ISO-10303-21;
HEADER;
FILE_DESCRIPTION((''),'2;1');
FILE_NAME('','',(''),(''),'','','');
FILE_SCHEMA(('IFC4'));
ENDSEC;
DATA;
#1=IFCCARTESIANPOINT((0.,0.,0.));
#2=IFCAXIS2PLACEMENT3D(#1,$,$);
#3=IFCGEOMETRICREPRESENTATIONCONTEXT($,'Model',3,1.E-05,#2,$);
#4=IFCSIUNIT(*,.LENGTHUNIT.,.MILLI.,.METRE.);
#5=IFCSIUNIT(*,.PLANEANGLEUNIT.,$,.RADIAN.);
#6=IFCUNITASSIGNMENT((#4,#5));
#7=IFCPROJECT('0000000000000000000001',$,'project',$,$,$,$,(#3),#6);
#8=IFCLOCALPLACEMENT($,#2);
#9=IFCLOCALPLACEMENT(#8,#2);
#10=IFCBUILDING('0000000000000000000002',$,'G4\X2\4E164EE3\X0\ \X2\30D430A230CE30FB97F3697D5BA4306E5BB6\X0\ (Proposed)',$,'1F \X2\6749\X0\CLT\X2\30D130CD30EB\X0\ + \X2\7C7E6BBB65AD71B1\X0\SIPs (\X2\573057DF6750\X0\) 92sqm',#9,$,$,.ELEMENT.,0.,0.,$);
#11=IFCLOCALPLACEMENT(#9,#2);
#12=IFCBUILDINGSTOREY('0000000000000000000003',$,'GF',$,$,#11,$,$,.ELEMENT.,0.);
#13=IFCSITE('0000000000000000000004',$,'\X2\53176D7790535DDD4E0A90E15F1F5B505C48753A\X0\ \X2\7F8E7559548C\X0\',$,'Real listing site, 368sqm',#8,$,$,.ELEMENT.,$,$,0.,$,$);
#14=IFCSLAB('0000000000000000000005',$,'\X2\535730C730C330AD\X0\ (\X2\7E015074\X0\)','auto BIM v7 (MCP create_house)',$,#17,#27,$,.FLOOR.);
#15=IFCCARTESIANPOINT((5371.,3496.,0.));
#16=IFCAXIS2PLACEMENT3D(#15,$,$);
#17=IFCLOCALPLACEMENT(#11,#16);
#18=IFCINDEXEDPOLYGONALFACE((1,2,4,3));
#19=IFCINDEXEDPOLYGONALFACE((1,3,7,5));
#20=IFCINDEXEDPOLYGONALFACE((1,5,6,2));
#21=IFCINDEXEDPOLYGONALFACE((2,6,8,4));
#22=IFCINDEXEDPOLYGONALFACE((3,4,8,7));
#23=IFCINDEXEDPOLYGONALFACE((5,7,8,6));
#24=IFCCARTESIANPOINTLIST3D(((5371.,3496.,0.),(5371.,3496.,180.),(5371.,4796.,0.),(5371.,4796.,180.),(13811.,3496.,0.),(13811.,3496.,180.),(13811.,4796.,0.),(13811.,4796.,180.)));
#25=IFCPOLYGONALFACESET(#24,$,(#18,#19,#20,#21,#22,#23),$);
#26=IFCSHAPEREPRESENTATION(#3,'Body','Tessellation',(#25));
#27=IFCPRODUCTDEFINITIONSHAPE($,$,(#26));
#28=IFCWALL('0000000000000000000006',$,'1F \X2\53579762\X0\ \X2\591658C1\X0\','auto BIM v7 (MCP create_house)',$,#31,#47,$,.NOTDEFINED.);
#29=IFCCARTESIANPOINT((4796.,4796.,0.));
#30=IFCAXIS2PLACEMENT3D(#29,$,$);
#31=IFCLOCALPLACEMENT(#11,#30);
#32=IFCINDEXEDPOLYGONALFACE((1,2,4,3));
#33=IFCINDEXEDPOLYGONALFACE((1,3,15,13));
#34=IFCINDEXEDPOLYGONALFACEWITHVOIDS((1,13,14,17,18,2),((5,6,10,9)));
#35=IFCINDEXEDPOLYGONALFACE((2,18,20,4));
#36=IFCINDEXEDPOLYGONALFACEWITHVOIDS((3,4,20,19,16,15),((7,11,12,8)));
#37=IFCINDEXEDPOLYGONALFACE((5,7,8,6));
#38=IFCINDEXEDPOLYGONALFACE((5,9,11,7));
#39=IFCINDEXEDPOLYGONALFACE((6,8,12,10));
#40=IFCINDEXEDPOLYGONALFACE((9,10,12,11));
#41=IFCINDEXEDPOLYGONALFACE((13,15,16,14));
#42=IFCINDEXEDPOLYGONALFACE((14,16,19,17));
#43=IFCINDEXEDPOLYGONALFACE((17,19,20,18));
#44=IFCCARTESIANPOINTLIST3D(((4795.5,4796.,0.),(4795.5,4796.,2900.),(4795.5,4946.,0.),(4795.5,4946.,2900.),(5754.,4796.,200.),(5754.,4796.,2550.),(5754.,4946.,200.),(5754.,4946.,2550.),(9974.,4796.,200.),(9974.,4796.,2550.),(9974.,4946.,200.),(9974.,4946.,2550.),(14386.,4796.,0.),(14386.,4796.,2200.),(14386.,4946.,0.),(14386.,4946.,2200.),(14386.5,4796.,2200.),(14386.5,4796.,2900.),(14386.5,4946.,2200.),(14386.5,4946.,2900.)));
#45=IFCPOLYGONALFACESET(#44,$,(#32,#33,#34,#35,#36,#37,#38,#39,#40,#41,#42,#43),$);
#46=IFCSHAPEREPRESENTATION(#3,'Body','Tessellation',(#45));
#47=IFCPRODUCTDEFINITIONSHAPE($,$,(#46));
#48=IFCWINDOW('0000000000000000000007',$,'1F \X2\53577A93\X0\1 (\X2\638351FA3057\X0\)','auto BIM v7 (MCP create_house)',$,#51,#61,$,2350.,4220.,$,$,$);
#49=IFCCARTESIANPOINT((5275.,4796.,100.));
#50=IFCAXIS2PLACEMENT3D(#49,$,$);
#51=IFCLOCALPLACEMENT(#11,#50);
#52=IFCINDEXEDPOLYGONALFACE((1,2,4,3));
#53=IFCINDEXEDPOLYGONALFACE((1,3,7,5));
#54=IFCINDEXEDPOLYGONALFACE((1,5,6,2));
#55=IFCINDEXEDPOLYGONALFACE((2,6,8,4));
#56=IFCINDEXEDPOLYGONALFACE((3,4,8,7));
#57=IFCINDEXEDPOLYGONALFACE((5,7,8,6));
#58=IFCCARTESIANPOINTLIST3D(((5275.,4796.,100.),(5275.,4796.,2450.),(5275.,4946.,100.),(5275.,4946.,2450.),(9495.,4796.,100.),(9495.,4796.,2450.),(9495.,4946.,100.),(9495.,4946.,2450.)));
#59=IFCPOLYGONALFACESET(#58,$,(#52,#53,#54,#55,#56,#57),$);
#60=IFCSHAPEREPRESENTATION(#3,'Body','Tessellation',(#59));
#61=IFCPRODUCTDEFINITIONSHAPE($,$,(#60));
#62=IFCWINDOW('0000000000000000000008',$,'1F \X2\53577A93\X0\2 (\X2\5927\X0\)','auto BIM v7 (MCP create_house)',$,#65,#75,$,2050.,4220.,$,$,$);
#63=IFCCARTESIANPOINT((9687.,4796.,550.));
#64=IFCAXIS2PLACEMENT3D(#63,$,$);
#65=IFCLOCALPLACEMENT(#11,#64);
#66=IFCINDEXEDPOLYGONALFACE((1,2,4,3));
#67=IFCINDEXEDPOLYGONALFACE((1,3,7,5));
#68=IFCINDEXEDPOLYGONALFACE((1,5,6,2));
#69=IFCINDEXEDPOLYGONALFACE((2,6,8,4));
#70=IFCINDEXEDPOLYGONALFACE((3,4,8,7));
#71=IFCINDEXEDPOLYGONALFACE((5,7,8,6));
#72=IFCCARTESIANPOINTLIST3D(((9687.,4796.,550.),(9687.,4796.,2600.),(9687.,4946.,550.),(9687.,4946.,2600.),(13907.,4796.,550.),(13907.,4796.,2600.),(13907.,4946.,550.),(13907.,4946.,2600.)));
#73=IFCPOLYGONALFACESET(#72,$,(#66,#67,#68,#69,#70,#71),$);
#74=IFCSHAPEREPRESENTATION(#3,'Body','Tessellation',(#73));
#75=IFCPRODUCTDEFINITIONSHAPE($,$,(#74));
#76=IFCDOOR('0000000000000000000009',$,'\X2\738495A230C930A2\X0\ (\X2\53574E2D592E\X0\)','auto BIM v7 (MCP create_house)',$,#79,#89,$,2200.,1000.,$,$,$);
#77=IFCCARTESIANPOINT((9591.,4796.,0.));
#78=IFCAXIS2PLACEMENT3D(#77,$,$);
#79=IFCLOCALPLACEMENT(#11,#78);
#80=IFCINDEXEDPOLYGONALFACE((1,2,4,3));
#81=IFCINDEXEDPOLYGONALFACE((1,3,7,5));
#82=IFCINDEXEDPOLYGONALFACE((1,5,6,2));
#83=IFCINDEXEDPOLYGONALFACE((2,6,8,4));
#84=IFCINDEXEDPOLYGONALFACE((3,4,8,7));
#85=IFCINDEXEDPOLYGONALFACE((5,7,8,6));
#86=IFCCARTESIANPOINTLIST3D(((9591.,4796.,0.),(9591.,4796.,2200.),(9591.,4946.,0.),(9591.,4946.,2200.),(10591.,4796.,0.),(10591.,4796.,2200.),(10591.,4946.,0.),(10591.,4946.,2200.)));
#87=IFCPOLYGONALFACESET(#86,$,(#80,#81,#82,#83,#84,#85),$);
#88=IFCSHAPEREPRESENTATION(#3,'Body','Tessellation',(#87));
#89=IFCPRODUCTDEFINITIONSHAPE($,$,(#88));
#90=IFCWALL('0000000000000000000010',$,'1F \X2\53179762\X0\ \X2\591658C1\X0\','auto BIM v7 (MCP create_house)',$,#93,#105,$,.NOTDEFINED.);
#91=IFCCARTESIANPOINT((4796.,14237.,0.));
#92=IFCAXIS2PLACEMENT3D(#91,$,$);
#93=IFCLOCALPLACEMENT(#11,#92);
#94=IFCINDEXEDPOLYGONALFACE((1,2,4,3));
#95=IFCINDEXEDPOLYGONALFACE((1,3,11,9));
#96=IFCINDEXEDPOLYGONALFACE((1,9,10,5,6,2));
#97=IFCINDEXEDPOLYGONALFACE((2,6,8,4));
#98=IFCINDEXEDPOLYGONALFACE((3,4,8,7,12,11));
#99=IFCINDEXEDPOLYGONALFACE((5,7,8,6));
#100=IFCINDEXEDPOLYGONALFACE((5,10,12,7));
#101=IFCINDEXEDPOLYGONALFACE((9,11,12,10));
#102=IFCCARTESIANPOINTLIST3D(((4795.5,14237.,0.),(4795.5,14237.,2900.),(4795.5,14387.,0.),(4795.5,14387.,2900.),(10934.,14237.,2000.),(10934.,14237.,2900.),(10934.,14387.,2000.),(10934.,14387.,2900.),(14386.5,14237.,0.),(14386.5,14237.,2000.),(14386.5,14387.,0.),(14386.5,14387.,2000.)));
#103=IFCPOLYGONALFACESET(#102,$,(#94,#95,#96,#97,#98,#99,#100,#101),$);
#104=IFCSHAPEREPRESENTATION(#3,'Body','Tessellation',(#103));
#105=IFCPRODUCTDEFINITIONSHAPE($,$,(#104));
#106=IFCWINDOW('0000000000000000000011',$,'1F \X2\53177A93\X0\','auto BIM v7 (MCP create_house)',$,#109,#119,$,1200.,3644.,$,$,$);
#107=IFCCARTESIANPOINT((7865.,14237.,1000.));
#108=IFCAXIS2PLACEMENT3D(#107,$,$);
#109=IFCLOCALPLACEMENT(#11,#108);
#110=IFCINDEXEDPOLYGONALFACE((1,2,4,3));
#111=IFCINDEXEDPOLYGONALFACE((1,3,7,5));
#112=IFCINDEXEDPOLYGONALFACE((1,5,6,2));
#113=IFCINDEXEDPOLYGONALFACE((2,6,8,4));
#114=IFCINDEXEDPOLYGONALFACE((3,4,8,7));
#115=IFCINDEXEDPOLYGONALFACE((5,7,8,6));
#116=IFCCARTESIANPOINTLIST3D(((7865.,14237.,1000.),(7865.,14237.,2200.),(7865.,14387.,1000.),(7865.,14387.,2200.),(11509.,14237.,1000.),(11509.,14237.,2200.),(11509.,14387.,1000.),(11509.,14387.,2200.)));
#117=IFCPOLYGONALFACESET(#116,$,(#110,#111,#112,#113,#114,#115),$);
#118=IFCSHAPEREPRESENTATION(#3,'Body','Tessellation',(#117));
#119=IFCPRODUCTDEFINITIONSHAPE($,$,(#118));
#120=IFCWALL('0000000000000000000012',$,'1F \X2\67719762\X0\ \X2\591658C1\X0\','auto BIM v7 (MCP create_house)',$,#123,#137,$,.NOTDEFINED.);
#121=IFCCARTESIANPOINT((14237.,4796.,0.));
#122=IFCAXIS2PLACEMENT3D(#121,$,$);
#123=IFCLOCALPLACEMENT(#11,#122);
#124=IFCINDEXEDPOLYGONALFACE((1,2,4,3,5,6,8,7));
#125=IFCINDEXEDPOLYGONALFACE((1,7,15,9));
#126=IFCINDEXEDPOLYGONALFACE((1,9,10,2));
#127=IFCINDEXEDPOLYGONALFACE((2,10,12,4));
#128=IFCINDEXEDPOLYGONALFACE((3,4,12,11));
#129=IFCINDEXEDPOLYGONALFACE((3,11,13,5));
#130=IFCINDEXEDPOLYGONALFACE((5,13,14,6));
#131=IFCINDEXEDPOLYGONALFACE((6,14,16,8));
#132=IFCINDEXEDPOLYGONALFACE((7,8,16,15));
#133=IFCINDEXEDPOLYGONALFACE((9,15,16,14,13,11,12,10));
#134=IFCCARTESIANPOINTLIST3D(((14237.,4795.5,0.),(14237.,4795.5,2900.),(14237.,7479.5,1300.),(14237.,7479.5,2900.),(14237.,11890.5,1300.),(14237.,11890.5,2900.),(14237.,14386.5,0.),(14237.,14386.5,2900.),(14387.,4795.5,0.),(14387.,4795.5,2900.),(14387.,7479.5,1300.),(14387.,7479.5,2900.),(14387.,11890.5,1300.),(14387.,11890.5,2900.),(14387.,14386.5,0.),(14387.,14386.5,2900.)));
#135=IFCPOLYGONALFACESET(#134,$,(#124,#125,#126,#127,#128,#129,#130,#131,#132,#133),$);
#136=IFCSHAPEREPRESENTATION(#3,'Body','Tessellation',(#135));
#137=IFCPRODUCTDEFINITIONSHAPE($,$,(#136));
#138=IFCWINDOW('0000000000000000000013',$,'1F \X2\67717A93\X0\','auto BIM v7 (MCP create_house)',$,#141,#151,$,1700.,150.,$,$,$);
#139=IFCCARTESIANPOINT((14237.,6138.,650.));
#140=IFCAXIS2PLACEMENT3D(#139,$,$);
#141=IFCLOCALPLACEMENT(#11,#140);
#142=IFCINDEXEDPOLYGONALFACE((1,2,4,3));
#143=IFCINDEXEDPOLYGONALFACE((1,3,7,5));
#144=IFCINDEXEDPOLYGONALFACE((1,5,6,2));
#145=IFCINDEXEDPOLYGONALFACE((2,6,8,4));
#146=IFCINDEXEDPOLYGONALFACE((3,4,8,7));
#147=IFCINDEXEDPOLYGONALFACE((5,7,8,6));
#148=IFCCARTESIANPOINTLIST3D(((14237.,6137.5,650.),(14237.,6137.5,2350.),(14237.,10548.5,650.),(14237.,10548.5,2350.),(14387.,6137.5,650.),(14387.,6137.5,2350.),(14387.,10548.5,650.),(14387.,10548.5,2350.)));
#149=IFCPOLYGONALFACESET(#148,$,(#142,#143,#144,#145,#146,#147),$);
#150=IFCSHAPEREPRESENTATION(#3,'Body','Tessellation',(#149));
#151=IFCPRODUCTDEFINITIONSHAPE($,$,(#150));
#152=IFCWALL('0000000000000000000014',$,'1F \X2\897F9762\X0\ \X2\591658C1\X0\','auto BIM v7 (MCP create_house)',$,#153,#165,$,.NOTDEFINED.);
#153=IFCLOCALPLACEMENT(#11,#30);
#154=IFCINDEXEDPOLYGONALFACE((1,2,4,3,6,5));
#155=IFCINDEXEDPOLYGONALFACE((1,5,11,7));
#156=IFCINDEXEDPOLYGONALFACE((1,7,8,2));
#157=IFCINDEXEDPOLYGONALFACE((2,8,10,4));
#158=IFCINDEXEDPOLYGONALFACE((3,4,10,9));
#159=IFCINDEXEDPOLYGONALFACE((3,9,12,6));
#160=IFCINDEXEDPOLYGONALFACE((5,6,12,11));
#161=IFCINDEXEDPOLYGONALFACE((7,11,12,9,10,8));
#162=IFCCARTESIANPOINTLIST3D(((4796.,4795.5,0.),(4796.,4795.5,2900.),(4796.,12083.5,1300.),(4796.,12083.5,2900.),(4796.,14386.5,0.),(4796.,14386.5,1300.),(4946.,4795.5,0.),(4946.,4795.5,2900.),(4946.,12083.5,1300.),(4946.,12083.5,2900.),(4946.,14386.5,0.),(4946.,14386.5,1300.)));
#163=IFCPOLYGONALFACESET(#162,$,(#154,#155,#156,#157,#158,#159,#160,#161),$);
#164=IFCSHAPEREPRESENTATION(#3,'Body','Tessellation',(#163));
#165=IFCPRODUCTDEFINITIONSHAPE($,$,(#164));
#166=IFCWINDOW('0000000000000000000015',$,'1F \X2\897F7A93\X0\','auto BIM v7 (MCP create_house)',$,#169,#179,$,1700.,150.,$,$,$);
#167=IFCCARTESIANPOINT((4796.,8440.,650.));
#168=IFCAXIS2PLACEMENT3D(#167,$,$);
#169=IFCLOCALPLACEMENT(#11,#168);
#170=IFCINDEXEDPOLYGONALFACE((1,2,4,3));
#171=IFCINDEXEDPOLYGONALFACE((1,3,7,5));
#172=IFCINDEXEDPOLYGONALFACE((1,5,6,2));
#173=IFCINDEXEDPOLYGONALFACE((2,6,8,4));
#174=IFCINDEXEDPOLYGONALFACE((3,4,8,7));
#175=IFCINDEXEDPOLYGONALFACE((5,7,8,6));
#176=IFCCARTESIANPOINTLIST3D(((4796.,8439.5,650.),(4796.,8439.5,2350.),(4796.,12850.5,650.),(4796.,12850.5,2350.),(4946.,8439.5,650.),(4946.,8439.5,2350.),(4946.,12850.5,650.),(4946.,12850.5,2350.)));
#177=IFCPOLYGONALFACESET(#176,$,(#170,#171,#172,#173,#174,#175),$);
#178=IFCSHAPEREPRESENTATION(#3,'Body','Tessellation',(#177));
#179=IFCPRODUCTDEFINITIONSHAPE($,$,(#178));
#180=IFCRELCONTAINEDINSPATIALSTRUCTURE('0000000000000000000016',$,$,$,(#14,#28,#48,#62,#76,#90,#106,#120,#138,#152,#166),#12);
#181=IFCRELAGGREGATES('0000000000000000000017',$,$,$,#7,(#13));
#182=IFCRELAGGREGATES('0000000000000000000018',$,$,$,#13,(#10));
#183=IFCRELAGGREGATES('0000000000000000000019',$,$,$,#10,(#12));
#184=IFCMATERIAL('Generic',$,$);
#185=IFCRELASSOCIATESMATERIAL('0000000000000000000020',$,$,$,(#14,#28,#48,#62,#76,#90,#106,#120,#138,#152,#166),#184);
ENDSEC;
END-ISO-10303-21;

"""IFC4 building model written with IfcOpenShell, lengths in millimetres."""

from ifc_helpers import new_model, si_unit, frame, frame_2d, origin, place, context, project, spatial, rectangle, extrude, material, element, fill, save


model = new_model("IFC4")

# Units and contexts
model_context = context("Model", 3, precision=1e-05, world=origin())
ifc_project = project(units=[si_unit("LENGTHUNIT", "METRE", prefix="MILLI"), si_unit("PLANEANGLEUNIT", "RADIAN")], contexts=[model_context])

# Site, building, storey
site_placement = place(None, origin())
site = spatial("IfcSite", under=ifc_project, at=site_placement, Name="北海道川上郡弟子屈町 美留和", ObjectType="Real listing site, 368sqm", CompositionType="ELEMENT", RefElevation=0.0)
building_placement = place(site_placement, origin())
building = spatial("IfcBuilding", under=site, at=building_placement, Name="G4世代 ピアノ・音楽室の家 (Proposed)", ObjectType="1F 杉CLTパネル + 籾殻断熱SIPs (地域材) 92sqm", CompositionType="ELEMENT", ElevationOfRefHeight=0.0, ElevationOfTerrain=0.0)
storey_placement = place(building_placement, origin())
storey = spatial("IfcBuildingStorey", under=building, at=storey_placement, Name="GF", CompositionType="ELEMENT", Elevation=0.0)

# Slab
ifc_material = material(Name="Generic")
slab_1_placement = place(storey_placement, frame((5371.0, 3496.0, 0.0)))
element("IfcSlab", 1, at=slab_1_placement, inside=storey, material=ifc_material, Name="南デッキ (縁側)", Description="auto BIM v7 (MCP create_house)", PredefinedType="FLOOR", context=model_context, shape_type="SweptSolid", body=[
    extrude(rectangle(XDim=8440.0, YDim=1300.0, at=frame_2d((4220.0, 650.0))), frame((5371.0, 3496.0, 0.0)), (0.0, 0.0, 1.0), 180.0),
])

# Wall, openings, windows, door
wall_1_placement = place(storey_placement, frame((4796.0, 4796.0, 0.0)))
wall_1 = element("IfcWall", 2, at=wall_1_placement, inside=storey, material=ifc_material, Name="1F 南面 外壁", Description="auto BIM v7 (MCP create_house)", PredefinedType="NOTDEFINED", context=model_context, shape_type="SweptSolid", body=[
    extrude(rectangle(XDim=9591.0, YDim=150.0, at=frame_2d((4795.0, 75.0))), frame((4796.0, 4796.0, 0.0)), (0.0, 0.0, 1.0), 2900.0),
])
opening_1_placement = place(storey_placement, frame((5275.0, 4796.0, 100.0)))
opening_1 = element("IfcOpeningElement", 3, at=opening_1_placement, cuts=wall_1, PredefinedType="NOTDEFINED", context=model_context, shape_type="SweptSolid", body=[
    extrude(rectangle(XDim=4220.0, YDim=150.0, at=frame_2d((2110.0, 75.0))), frame((5275.0, 4796.0, 100.0)), (0.0, 0.0, 1.0), 2350.0),
])
opening_2_placement = place(storey_placement, frame((9687.0, 4796.0, 550.0)))
opening_2 = element("IfcOpeningElement", 4, at=opening_2_placement, cuts=wall_1, PredefinedType="NOTDEFINED", context=model_context, shape_type="SweptSolid", body=[
    extrude(rectangle(XDim=4220.0, YDim=150.0, at=frame_2d((2110.0, 75.0))), frame((9687.0, 4796.0, 550.0)), (0.0, 0.0, 1.0), 2050.0),
])
opening_3_placement = place(storey_placement, frame((9591.0, 4796.0, 0.0)))
opening_3 = element("IfcOpeningElement", 5, at=opening_3_placement, cuts=wall_1, PredefinedType="NOTDEFINED", context=model_context, shape_type="SweptSolid", body=[
    extrude(rectangle(XDim=1000.0, YDim=150.0, at=frame_2d((500.0, 75.0))), frame((9591.0, 4796.0, 0.0)), (0.0, 0.0, 1.0), 2200.0),
])
window_1_placement = place(storey_placement, frame((5275.0, 4796.0, 100.0)))
window_1 = element("IfcWindow", 6, at=window_1_placement, inside=storey, material=ifc_material, Name="1F 南窓1 (掃出し)", Description="auto BIM v7 (MCP create_house)", OverallHeight=2350.0, OverallWidth=4220.0, context=model_context, shape_type="SweptSolid", body=[
    extrude(rectangle(XDim=4220.0, YDim=150.0, at=frame_2d((2110.0, 75.0))), frame((5275.0, 4796.0, 100.0)), (0.0, 0.0, 1.0), 2350.0),
])
fill(opening_1, window_1)
window_2_placement = place(storey_placement, frame((9687.0, 4796.0, 550.0)))
window_2 = element("IfcWindow", 7, at=window_2_placement, inside=storey, material=ifc_material, Name="1F 南窓2 (大)", Description="auto BIM v7 (MCP create_house)", OverallHeight=2050.0, OverallWidth=4220.0, context=model_context, shape_type="SweptSolid", body=[
    extrude(rectangle(XDim=4220.0, YDim=150.0, at=frame_2d((2110.0, 75.0))), frame((9687.0, 4796.0, 550.0)), (0.0, 0.0, 1.0), 2050.0),
])
fill(opening_2, window_2)
door_placement = place(storey_placement, frame((9591.0, 4796.0, 0.0)))
door = element("IfcDoor", 8, at=door_placement, inside=storey, material=ifc_material, Name="玄関ドア (南中央)", Description="auto BIM v7 (MCP create_house)", OverallHeight=2200.0, OverallWidth=1000.0, context=model_context, shape_type="SweptSolid", body=[
    extrude(rectangle(XDim=1000.0, YDim=150.0, at=frame_2d((500.0, 75.0))), frame((9591.0, 4796.0, 0.0)), (0.0, 0.0, 1.0), 2200.0),
])
fill(opening_3, door)

# Walls, openings, windows
wall_2_placement = place(storey_placement, frame((4796.0, 14237.0, 0.0)))
wall_2 = element("IfcWall", 9, at=wall_2_placement, inside=storey, material=ifc_material, Name="1F 北面 外壁", Description="auto BIM v7 (MCP create_house)", PredefinedType="NOTDEFINED", context=model_context, shape_type="SweptSolid", body=[
    extrude(rectangle(XDim=9591.0, YDim=150.0, at=frame_2d((4795.0, 75.0))), frame((4796.0, 14237.0, 0.0)), (0.0, 0.0, 1.0), 2900.0),
])
opening_4_placement = place(storey_placement, frame((7865.0, 14237.0, 1000.0)))
opening_4 = element("IfcOpeningElement", 10, at=opening_4_placement, cuts=wall_2, PredefinedType="NOTDEFINED", context=model_context, shape_type="SweptSolid", body=[
    extrude(rectangle(XDim=3644.0, YDim=150.0, at=frame_2d((1822.0, 75.0))), frame((7865.0, 14237.0, 1000.0)), (0.0, 0.0, 1.0), 1200.0),
])
window_3_placement = place(storey_placement, frame((7865.0, 14237.0, 1000.0)))
window_3 = element("IfcWindow", 11, at=window_3_placement, inside=storey, material=ifc_material, Name="1F 北窓", Description="auto BIM v7 (MCP create_house)", OverallHeight=1200.0, OverallWidth=3644.0, context=model_context, shape_type="SweptSolid", body=[
    extrude(rectangle(XDim=3644.0, YDim=150.0, at=frame_2d((1822.0, 75.0))), frame((7865.0, 14237.0, 1000.0)), (0.0, 0.0, 1.0), 1200.0),
])
fill(opening_4, window_3)
wall_3_placement = place(storey_placement, frame((14237.0, 4796.0, 0.0)))
wall_3 = element("IfcWall", 12, at=wall_3_placement, inside=storey, material=ifc_material, Name="1F 東面 外壁", Description="auto BIM v7 (MCP create_house)", PredefinedType="NOTDEFINED", context=model_context, shape_type="SweptSolid", body=[
    extrude(rectangle(XDim=150.0, YDim=9591.0, at=frame_2d((75.0, 4795.0))), frame((14237.0, 4796.0, 0.0)), (0.0, 0.0, 1.0), 2900.0),
])
opening_5_placement = place(storey_placement, frame((14237.0, 6138.0, 650.0)))
opening_5 = element("IfcOpeningElement", 13, at=opening_5_placement, cuts=wall_3, PredefinedType="NOTDEFINED", context=model_context, shape_type="SweptSolid", body=[
    extrude(rectangle(XDim=150.0, YDim=4411.0, at=frame_2d((75.0, 2205.0))), frame((14237.0, 6138.0, 650.0)), (0.0, 0.0, 1.0), 1700.0),
])
window_4_placement = place(storey_placement, frame((14237.0, 6138.0, 650.0)))
window_4 = element("IfcWindow", 14, at=window_4_placement, inside=storey, material=ifc_material, Name="1F 東窓", Description="auto BIM v7 (MCP create_house)", OverallHeight=1700.0, OverallWidth=150.0, context=model_context, shape_type="SweptSolid", body=[
    extrude(rectangle(XDim=150.0, YDim=4411.0, at=frame_2d((75.0, 2205.0))), frame((14237.0, 6138.0, 650.0)), (0.0, 0.0, 1.0), 1700.0),
])
fill(opening_5, window_4)
wall_4_placement = place(storey_placement, frame((4796.0, 4796.0, 0.0)))
wall_4 = element("IfcWall", 15, at=wall_4_placement, inside=storey, material=ifc_material, Name="1F 西面 外壁", Description="auto BIM v7 (MCP create_house)", PredefinedType="NOTDEFINED", context=model_context, shape_type="SweptSolid", body=[
    extrude(rectangle(XDim=150.0, YDim=9591.0, at=frame_2d((75.0, 4795.0))), frame((4796.0, 4796.0, 0.0)), (0.0, 0.0, 1.0), 2900.0),
])
opening_6_placement = place(storey_placement, frame((4796.0, 8440.0, 650.0)))
opening_6 = element("IfcOpeningElement", 16, at=opening_6_placement, cuts=wall_4, PredefinedType="NOTDEFINED", context=model_context, shape_type="SweptSolid", body=[
    extrude(rectangle(XDim=150.0, YDim=4411.0, at=frame_2d((75.0, 2205.0))), frame((4796.0, 8440.0, 650.0)), (0.0, 0.0, 1.0), 1700.0),
])
window_5_placement = place(storey_placement, frame((4796.0, 8440.0, 650.0)))
window_5 = element("IfcWindow", 17, at=window_5_placement, inside=storey, material=ifc_material, Name="1F 西窓", Description="auto BIM v7 (MCP create_house)", OverallHeight=1700.0, OverallWidth=150.0, context=model_context, shape_type="SweptSolid", body=[
    extrude(rectangle(XDim=150.0, YDim=4411.0, at=frame_2d((75.0, 2205.0))), frame((4796.0, 8440.0, 650.0)), (0.0, 0.0, 1.0), 1700.0),
])
fill(opening_6, window_5)

save(model, "model.ifc")
